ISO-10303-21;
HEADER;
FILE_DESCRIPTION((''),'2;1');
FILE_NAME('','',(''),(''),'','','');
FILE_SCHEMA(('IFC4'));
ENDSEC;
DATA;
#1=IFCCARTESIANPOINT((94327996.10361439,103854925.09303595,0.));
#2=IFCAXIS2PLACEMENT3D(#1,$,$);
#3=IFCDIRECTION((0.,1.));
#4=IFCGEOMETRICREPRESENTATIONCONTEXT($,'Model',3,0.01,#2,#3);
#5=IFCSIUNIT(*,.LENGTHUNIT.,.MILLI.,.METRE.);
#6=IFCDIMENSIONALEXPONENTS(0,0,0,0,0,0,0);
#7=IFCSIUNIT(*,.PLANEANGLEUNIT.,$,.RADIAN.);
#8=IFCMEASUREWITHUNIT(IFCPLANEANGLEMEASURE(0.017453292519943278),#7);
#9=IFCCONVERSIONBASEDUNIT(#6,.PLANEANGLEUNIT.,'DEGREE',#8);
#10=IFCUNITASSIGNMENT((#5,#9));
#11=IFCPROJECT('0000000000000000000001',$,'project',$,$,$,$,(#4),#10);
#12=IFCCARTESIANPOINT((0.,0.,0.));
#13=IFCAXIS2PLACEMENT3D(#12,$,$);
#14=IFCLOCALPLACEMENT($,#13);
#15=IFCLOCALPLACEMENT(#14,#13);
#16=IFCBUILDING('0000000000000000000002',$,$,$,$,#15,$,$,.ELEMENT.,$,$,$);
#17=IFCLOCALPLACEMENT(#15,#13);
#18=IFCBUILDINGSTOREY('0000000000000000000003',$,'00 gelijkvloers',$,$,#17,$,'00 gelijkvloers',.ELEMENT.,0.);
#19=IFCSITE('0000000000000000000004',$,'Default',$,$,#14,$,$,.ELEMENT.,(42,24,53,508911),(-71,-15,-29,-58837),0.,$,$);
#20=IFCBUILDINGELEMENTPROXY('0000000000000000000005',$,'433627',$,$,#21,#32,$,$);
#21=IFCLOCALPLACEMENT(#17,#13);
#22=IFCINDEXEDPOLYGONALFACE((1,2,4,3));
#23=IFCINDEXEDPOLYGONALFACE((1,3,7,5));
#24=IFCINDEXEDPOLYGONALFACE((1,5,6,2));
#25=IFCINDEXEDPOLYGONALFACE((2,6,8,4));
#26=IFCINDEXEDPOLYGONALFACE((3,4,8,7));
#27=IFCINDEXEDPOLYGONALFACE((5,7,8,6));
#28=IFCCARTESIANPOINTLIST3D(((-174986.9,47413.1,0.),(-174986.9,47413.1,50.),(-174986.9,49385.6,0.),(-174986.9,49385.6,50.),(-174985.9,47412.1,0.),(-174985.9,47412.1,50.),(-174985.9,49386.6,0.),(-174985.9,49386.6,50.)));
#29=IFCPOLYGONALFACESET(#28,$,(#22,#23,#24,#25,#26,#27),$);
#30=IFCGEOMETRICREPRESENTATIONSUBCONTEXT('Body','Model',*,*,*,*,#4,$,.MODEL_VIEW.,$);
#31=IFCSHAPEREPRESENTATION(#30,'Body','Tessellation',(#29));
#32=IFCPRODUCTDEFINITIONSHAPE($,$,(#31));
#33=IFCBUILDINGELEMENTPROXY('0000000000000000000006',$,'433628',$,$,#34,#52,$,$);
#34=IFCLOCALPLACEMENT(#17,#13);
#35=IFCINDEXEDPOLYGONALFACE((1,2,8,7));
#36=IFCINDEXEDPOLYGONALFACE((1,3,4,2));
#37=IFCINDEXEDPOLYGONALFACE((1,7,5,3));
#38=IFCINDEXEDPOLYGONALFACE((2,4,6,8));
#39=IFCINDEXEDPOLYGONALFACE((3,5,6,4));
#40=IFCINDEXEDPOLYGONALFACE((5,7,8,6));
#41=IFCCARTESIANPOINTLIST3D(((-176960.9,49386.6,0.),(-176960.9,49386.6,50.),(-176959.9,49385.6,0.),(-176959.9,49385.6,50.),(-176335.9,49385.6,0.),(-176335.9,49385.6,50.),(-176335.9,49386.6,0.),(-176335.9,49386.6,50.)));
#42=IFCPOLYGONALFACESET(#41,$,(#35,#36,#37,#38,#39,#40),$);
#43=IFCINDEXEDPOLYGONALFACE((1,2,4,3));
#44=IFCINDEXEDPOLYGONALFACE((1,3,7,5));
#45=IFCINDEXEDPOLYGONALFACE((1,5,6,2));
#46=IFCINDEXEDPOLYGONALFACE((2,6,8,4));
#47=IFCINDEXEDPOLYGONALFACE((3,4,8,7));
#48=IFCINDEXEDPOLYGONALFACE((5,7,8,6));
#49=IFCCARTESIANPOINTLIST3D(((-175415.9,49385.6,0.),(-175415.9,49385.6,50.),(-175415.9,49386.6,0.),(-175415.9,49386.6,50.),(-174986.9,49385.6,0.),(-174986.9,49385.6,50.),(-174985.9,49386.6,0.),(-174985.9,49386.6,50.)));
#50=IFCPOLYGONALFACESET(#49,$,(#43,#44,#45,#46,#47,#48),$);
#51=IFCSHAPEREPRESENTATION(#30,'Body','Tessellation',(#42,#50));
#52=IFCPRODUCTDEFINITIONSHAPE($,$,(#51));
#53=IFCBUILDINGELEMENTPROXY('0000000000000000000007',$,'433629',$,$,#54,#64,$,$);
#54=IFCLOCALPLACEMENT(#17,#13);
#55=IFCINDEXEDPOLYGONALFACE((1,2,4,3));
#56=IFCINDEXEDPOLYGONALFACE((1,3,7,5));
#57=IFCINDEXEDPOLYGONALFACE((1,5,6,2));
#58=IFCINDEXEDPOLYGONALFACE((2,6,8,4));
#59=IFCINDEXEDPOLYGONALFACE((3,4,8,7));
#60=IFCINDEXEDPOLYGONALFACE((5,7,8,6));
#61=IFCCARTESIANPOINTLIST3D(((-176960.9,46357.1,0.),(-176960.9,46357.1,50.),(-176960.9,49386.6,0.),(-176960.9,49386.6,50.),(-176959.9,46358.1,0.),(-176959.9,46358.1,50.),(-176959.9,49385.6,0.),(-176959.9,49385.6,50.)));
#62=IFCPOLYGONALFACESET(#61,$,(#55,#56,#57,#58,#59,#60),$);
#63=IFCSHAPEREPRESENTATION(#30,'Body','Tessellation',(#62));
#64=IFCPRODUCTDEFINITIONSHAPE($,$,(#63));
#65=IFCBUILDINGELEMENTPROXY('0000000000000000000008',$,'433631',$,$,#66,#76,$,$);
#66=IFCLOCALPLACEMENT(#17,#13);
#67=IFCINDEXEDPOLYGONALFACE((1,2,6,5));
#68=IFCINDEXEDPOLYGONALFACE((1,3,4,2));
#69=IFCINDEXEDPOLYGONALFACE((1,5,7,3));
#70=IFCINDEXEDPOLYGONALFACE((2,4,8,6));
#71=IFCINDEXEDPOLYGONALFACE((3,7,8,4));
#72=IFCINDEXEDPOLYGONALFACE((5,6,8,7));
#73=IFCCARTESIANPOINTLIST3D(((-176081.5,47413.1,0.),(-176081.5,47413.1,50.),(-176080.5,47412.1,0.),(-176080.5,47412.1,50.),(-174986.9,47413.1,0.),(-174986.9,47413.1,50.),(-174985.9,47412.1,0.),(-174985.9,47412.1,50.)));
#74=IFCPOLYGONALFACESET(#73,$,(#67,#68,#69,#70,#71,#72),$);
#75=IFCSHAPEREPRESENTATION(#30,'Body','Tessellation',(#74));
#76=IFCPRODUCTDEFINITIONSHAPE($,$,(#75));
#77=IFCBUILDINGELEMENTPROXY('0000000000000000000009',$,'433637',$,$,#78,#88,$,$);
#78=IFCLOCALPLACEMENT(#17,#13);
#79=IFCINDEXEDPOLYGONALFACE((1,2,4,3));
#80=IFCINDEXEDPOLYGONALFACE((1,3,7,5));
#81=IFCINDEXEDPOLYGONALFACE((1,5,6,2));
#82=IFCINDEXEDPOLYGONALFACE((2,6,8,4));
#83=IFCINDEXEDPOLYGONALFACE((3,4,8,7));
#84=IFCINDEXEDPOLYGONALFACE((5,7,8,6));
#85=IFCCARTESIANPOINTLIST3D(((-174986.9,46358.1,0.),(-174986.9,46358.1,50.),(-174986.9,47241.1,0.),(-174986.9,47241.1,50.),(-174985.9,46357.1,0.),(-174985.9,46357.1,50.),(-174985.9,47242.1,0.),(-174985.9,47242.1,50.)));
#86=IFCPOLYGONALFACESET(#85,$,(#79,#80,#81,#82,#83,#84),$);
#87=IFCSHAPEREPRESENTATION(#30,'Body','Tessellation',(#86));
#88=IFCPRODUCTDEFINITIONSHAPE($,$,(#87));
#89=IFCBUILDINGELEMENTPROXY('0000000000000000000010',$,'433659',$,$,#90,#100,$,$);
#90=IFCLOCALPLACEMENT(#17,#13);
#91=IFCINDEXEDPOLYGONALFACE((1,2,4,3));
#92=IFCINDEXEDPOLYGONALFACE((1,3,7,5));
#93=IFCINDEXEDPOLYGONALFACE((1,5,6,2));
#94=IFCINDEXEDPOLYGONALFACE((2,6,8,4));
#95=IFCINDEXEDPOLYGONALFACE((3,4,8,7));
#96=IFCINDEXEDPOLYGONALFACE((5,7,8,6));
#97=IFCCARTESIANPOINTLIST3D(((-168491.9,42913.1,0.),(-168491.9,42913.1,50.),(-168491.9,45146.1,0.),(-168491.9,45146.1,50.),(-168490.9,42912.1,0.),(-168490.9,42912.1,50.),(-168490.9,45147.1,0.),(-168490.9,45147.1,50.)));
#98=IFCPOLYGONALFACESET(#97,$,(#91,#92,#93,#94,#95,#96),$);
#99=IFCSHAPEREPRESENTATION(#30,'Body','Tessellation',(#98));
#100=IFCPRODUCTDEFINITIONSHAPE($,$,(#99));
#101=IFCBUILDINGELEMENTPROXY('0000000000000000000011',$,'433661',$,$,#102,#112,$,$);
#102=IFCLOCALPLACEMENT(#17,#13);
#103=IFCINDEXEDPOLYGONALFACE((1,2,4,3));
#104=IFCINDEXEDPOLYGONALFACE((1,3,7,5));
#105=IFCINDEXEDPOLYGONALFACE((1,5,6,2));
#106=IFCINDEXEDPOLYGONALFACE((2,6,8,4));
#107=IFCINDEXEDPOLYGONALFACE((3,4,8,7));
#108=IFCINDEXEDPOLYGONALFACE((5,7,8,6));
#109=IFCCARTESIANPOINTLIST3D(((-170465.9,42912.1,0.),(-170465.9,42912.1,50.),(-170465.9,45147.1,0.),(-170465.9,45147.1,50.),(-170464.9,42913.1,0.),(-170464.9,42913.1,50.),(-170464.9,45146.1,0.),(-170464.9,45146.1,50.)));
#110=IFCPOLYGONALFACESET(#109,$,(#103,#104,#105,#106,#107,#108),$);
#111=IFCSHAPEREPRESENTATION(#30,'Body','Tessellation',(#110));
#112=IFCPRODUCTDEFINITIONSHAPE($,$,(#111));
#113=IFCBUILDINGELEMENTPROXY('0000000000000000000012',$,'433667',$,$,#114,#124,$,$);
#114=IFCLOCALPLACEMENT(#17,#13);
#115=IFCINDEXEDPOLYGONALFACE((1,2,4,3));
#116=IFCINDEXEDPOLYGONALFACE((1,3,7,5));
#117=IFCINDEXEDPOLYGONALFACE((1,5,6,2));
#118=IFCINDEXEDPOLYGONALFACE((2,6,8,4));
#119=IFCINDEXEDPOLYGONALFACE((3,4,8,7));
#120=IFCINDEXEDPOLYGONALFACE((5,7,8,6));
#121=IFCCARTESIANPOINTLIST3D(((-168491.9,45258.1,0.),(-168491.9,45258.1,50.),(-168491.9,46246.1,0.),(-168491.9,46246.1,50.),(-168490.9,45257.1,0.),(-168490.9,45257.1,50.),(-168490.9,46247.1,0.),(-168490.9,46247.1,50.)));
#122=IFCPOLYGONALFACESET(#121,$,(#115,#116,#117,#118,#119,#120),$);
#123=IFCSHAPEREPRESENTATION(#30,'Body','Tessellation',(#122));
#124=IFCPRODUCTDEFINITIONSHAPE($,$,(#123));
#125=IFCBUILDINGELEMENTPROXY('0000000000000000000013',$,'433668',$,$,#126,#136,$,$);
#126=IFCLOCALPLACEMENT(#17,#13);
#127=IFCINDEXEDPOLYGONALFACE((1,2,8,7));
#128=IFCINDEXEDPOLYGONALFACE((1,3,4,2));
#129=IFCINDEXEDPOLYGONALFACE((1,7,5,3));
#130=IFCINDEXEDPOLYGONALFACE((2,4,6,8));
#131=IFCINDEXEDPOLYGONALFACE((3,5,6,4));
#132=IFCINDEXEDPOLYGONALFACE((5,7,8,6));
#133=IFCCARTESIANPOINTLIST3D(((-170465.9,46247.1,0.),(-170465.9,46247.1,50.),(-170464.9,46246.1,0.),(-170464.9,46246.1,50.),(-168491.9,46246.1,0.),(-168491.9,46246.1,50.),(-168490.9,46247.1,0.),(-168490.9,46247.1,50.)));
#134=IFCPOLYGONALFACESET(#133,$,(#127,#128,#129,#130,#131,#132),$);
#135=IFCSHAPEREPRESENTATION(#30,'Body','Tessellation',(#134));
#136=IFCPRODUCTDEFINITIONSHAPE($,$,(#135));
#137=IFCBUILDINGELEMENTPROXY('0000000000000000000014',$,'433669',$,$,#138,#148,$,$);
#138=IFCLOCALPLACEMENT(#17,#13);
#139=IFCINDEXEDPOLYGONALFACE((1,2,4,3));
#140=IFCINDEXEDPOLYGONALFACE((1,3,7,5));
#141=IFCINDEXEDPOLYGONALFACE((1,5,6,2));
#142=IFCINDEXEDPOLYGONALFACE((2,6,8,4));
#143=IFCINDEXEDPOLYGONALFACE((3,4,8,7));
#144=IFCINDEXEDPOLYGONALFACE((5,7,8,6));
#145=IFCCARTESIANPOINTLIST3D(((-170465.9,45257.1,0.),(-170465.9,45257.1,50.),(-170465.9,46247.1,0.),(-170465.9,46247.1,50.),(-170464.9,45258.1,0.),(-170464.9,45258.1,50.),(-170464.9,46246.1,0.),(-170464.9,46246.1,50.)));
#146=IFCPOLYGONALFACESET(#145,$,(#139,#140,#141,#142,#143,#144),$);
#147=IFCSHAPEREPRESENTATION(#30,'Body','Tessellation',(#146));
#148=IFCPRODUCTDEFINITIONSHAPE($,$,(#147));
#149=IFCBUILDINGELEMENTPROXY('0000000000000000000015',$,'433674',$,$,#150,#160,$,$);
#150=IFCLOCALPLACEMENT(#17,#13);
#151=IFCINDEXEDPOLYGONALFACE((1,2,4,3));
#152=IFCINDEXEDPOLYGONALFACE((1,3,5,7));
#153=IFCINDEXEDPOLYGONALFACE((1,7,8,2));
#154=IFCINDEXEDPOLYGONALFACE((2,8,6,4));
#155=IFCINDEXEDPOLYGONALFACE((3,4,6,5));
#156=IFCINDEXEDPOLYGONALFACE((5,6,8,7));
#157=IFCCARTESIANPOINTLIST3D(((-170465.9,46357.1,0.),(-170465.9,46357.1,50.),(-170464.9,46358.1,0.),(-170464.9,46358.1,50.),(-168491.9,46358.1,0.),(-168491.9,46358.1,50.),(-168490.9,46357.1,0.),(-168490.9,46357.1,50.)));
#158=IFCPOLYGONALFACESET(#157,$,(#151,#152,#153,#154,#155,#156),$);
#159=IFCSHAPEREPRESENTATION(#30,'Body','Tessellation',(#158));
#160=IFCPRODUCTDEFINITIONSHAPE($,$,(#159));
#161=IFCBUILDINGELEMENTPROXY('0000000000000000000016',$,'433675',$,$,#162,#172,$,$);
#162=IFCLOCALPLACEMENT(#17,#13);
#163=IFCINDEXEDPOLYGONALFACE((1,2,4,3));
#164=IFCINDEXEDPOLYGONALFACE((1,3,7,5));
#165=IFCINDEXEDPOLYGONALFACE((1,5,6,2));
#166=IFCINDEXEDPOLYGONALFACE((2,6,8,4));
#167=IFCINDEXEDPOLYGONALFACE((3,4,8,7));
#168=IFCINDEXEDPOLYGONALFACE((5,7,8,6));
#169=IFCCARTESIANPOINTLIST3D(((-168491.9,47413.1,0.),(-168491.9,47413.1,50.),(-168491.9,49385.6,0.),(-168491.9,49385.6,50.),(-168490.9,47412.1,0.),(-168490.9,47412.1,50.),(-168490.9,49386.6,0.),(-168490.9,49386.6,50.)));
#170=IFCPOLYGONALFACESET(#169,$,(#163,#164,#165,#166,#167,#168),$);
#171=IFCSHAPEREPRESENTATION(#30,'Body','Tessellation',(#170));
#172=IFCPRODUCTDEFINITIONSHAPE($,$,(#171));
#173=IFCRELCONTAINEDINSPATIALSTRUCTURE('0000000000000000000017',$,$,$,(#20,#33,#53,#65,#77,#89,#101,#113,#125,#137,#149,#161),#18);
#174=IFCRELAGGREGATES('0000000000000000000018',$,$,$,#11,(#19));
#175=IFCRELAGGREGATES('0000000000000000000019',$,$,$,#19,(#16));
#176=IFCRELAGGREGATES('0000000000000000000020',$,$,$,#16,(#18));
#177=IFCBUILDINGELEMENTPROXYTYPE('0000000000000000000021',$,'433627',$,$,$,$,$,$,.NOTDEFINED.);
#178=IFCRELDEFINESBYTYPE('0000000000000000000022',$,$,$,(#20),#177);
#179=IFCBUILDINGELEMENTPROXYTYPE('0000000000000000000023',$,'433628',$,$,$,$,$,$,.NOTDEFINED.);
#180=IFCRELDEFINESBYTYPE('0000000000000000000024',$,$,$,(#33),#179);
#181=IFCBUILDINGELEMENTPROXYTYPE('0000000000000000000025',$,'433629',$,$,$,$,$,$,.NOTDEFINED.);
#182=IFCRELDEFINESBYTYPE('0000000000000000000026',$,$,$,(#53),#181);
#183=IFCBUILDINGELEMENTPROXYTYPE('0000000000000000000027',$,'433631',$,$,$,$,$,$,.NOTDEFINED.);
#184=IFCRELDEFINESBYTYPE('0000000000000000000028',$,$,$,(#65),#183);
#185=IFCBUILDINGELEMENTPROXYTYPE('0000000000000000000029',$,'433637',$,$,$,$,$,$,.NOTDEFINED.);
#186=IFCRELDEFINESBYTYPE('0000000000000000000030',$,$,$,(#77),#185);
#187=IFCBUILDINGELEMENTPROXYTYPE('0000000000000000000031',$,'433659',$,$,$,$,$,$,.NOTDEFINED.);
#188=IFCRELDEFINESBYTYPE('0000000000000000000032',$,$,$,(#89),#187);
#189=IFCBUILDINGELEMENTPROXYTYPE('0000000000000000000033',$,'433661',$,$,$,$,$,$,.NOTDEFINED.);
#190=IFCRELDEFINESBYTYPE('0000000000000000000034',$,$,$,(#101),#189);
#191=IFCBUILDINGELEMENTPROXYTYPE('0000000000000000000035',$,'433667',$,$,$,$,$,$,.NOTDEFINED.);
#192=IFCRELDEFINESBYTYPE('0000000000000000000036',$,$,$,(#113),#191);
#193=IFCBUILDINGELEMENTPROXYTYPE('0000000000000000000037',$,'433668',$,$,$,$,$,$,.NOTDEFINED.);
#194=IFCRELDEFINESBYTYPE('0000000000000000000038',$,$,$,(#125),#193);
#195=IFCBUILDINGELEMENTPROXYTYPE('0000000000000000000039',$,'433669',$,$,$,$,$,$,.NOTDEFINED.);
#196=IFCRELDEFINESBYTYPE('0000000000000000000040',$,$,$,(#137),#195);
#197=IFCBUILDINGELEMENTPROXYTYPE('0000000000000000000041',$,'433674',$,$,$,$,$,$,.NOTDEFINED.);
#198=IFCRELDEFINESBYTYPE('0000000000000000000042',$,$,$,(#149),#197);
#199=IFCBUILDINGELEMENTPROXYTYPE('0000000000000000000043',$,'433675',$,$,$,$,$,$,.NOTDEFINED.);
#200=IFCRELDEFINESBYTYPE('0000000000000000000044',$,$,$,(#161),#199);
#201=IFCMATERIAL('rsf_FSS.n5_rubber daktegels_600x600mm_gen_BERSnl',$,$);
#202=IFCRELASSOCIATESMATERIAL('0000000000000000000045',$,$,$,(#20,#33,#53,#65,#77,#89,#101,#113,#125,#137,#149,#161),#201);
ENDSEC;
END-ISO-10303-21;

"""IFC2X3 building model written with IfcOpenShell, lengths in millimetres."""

from ifc_helpers import new_model, entity, si_unit, converted_unit, direction, frame, origin, place, context, subcontext, project, spatial, polyline, outline, extrude, material, type_object, element, save


model = new_model("IFC2X3")

# Units and contexts
model_context = context("Model", 3, precision=0.01, world=frame((94327996.10361439, 103854925.09303595, 0.0)), true_north=direction((0.0, 1.0)))
body_context = subcontext(model_context, "Body", "Model", "MODEL_VIEW")
ifc_project = project(units=[si_unit("LENGTHUNIT", "METRE", prefix="MILLI"), converted_unit("PLANEANGLEUNIT", "DEGREE", entity("IfcPlaneAngleMeasure", 0.017453292519943278), si_unit("PLANEANGLEUNIT", "RADIAN"), dimensions=[0, 0, 0, 0, 0, 0, 0])], contexts=[model_context])

# Site, building, storey
site_placement = place(None, origin())
site = spatial("IfcSite", under=ifc_project, at=site_placement, Name="Default", CompositionType="ELEMENT", RefLatitude=(42, 24, 53, 508911), RefLongitude=(-71, -15, -29, -58837), RefElevation=0.0)
building_placement = place(site_placement, origin())
building = spatial("IfcBuilding", under=site, at=building_placement, CompositionType="ELEMENT")
storey_placement = place(building_placement, origin())
storey = spatial("IfcBuildingStorey", under=building, at=storey_placement, Name="00 gelijkvloers", LongName="00 gelijkvloers", CompositionType="ELEMENT", Elevation=0.0)

# Building element proxies
ifc_material = material(Name="rsf_FSS.n5_rubber daktegels_600x600mm_gen_BERSnl")
building_element_proxy_type_1 = type_object("IfcBuildingElementProxyType", Name="433627", PredefinedType="NOTDEFINED")
proxy_1_placement = place(storey_placement, origin())
element("IfcBuildingElementProxy", 1, at=proxy_1_placement, inside=storey, type_object=building_element_proxy_type_1, material=ifc_material, Name="433627", context=body_context, shape_type="SweptSolid", body=[
    extrude(outline(polyline([(-986.3, -0.5), (986.3, -0.5), (987.3, 0.5), (-987.3, 0.5), (-986.3, -0.5)])), frame((-174986.4, 48399.3, 0.0), z_axis=(0.0, 0.0, 1.0), x_axis=(0.0, -1.0, 0.0)), (0.0, 0.0, 1.0), 50.0),
])
building_element_proxy_type_2 = type_object("IfcBuildingElementProxyType", Name="433628", PredefinedType="NOTDEFINED")
proxy_2_placement = place(storey_placement, origin())
element("IfcBuildingElementProxy", 2, at=proxy_2_placement, inside=storey, type_object=building_element_proxy_type_2, material=ifc_material, Name="433628", context=body_context, shape_type="SweptSolid", body=[
    extrude(outline(polyline([(-311.7, -0.5), (312.2, -0.5), (312.2, 0.5), (-312.7, 0.5), (-311.7, -0.5)])), frame((-176648.1, 49386.1, 0.0)), (0.0, 0.0, 1.0), 50.0),
    extrude(outline(polyline([(-214.8, -0.5), (214.3, -0.5), (215.3, 0.5), (-214.8, 0.5), (-214.8, -0.5)])), frame((-175201.1, 49386.1, 0.0)), (0.0, 0.0, 1.0), 50.0),
])
building_element_proxy_type_3 = type_object("IfcBuildingElementProxyType", Name="433629", PredefinedType="NOTDEFINED")
proxy_3_placement = place(storey_placement, origin())
element("IfcBuildingElementProxy", 3, at=proxy_3_placement, inside=storey, type_object=building_element_proxy_type_3, material=ifc_material, Name="433629", context=body_context, shape_type="SweptSolid", body=[
    extrude(outline(polyline([(-1513.8, -0.5), (1513.8, -0.5), (1514.8, 0.5), (-1514.8, 0.5), (-1513.8, -0.5)])), frame((-176960.4, 47871.8, 0.0), z_axis=(0.0, 0.0, 1.0), x_axis=(0.0, 1.0, 0.0)), (0.0, 0.0, 1.0), 50.0),
])
building_element_proxy_type_4 = type_object("IfcBuildingElementProxyType", Name="433631", PredefinedType="NOTDEFINED")
proxy_4_placement = place(storey_placement, origin())
element("IfcBuildingElementProxy", 4, at=proxy_4_placement, inside=storey, type_object=building_element_proxy_type_4, material=ifc_material, Name="433631", context=body_context, shape_type="SweptSolid", body=[
    extrude(outline(polyline([(-546.8, -0.5), (547.8, -0.5), (546.8, 0.5), (-547.8, 0.5), (-546.8, -0.5)])), frame((-175533.7, 47412.6, 0.0), z_axis=(0.0, 0.0, 1.0), x_axis=(-1.0, 0.0, 0.0)), (0.0, 0.0, 1.0), 50.0),
])
building_element_proxy_type_5 = type_object("IfcBuildingElementProxyType", Name="433637", PredefinedType="NOTDEFINED")
proxy_5_placement = place(storey_placement, origin())
element("IfcBuildingElementProxy", 5, at=proxy_5_placement, inside=storey, type_object=building_element_proxy_type_5, material=ifc_material, Name="433637", context=body_context, shape_type="SweptSolid", body=[
    extrude(outline(polyline([(-441.5, -0.5), (441.5, -0.5), (442.5, 0.5), (-442.5, 0.5), (-441.5, -0.5)])), frame((-174986.4, 46799.6, 0.0), z_axis=(0.0, 0.0, 1.0), x_axis=(0.0, -1.0, 0.0)), (0.0, 0.0, 1.0), 50.0),
])
building_element_proxy_type_6 = type_object("IfcBuildingElementProxyType", Name="433659", PredefinedType="NOTDEFINED")
proxy_6_placement = place(storey_placement, origin())
element("IfcBuildingElementProxy", 6, at=proxy_6_placement, inside=storey, type_object=building_element_proxy_type_6, material=ifc_material, Name="433659", context=body_context, shape_type="SweptSolid", body=[
    extrude(outline(polyline([(-1116.5, -0.5), (1116.5, -0.5), (1117.5, 0.5), (-1117.5, 0.5), (-1116.5, -0.5)])), frame((-168491.4, 44029.6, 0.0), z_axis=(0.0, 0.0, 1.0), x_axis=(0.0, -1.0, 0.0)), (0.0, 0.0, 1.0), 50.0),
])
building_element_proxy_type_7 = type_object("IfcBuildingElementProxyType", Name="433661", PredefinedType="NOTDEFINED")
proxy_7_placement = place(storey_placement, origin())
element("IfcBuildingElementProxy", 7, at=proxy_7_placement, inside=storey, type_object=building_element_proxy_type_7, material=ifc_material, Name="433661", context=body_context, shape_type="SweptSolid", body=[
    extrude(outline(polyline([(-1116.5, -0.5), (1116.5, -0.5), (1117.5, 0.5), (-1117.5, 0.5), (-1116.5, -0.5)])), frame((-170465.4, 44029.6, 0.0), z_axis=(0.0, 0.0, 1.0), x_axis=(0.0, 1.0, 0.0)), (0.0, 0.0, 1.0), 50.0),
])
building_element_proxy_type_8 = type_object("IfcBuildingElementProxyType", Name="433667", PredefinedType="NOTDEFINED")
proxy_8_placement = place(storey_placement, origin())
element("IfcBuildingElementProxy", 8, at=proxy_8_placement, inside=storey, type_object=building_element_proxy_type_8, material=ifc_material, Name="433667", context=body_context, shape_type="SweptSolid", body=[
    extrude(outline(polyline([(-494.0, -0.5), (494.0, -0.5), (495.0, 0.5), (-495.0, 0.5), (-494.0, -0.5)])), frame((-168491.4, 45752.1, 0.0), z_axis=(0.0, 0.0, 1.0), x_axis=(0.0, -1.0, 0.0)), (0.0, 0.0, 1.0), 50.0),
])
building_element_proxy_type_9 = type_object("IfcBuildingElementProxyType", Name="433668", PredefinedType="NOTDEFINED")
proxy_9_placement = place(storey_placement, origin())
element("IfcBuildingElementProxy", 9, at=proxy_9_placement, inside=storey, type_object=building_element_proxy_type_9, material=ifc_material, Name="433668", context=body_context, shape_type="SweptSolid", body=[
    extrude(outline(polyline([(-986.5, -0.5), (986.5, -0.5), (987.5, 0.5), (-987.5, 0.5), (-986.5, -0.5)])), frame((-169478.4, 46246.6, 0.0)), (0.0, 0.0, 1.0), 50.0),
])
building_element_proxy_type_10 = type_object("IfcBuildingElementProxyType", Name="433669", PredefinedType="NOTDEFINED")
proxy_10_placement = place(storey_placement, origin())
element("IfcBuildingElementProxy", 10, at=proxy_10_placement, inside=storey, type_object=building_element_proxy_type_10, material=ifc_material, Name="433669", context=body_context, shape_type="SweptSolid", body=[
    extrude(outline(polyline([(-494.0, -0.5), (494.0, -0.5), (495.0, 0.5), (-495.0, 0.5), (-494.0, -0.5)])), frame((-170465.4, 45752.1, 0.0), z_axis=(0.0, 0.0, 1.0), x_axis=(0.0, 1.0, 0.0)), (0.0, 0.0, 1.0), 50.0),
])
building_element_proxy_type_11 = type_object("IfcBuildingElementProxyType", Name="433674", PredefinedType="NOTDEFINED")
proxy_11_placement = place(storey_placement, origin())
element("IfcBuildingElementProxy", 11, at=proxy_11_placement, inside=storey, type_object=building_element_proxy_type_11, material=ifc_material, Name="433674", context=body_context, shape_type="SweptSolid", body=[
    extrude(outline(polyline([(-986.5, -0.5), (986.5, -0.5), (987.5, 0.5), (-987.5, 0.5), (-986.5, -0.5)])), frame((-169478.4, 46357.6, 0.0), z_axis=(0.0, 0.0, 1.0), x_axis=(-1.0, 0.0, 0.0)), (0.0, 0.0, 1.0), 50.0),
])
building_element_proxy_type_12 = type_object("IfcBuildingElementProxyType", Name="433675", PredefinedType="NOTDEFINED")
proxy_12_placement = place(storey_placement, origin())
element("IfcBuildingElementProxy", 12, at=proxy_12_placement, inside=storey, type_object=building_element_proxy_type_12, material=ifc_material, Name="433675", context=body_context, shape_type="SweptSolid", body=[
    extrude(outline(polyline([(-986.3, -0.5), (986.3, -0.5), (987.3, 0.5), (-987.3, 0.5), (-986.3, -0.5)])), frame((-168491.4, 48399.3, 0.0), z_axis=(0.0, 0.0, 1.0), x_axis=(0.0, -1.0, 0.0)), (0.0, 0.0, 1.0), 50.0),
])

save(model, "model.ifc")
